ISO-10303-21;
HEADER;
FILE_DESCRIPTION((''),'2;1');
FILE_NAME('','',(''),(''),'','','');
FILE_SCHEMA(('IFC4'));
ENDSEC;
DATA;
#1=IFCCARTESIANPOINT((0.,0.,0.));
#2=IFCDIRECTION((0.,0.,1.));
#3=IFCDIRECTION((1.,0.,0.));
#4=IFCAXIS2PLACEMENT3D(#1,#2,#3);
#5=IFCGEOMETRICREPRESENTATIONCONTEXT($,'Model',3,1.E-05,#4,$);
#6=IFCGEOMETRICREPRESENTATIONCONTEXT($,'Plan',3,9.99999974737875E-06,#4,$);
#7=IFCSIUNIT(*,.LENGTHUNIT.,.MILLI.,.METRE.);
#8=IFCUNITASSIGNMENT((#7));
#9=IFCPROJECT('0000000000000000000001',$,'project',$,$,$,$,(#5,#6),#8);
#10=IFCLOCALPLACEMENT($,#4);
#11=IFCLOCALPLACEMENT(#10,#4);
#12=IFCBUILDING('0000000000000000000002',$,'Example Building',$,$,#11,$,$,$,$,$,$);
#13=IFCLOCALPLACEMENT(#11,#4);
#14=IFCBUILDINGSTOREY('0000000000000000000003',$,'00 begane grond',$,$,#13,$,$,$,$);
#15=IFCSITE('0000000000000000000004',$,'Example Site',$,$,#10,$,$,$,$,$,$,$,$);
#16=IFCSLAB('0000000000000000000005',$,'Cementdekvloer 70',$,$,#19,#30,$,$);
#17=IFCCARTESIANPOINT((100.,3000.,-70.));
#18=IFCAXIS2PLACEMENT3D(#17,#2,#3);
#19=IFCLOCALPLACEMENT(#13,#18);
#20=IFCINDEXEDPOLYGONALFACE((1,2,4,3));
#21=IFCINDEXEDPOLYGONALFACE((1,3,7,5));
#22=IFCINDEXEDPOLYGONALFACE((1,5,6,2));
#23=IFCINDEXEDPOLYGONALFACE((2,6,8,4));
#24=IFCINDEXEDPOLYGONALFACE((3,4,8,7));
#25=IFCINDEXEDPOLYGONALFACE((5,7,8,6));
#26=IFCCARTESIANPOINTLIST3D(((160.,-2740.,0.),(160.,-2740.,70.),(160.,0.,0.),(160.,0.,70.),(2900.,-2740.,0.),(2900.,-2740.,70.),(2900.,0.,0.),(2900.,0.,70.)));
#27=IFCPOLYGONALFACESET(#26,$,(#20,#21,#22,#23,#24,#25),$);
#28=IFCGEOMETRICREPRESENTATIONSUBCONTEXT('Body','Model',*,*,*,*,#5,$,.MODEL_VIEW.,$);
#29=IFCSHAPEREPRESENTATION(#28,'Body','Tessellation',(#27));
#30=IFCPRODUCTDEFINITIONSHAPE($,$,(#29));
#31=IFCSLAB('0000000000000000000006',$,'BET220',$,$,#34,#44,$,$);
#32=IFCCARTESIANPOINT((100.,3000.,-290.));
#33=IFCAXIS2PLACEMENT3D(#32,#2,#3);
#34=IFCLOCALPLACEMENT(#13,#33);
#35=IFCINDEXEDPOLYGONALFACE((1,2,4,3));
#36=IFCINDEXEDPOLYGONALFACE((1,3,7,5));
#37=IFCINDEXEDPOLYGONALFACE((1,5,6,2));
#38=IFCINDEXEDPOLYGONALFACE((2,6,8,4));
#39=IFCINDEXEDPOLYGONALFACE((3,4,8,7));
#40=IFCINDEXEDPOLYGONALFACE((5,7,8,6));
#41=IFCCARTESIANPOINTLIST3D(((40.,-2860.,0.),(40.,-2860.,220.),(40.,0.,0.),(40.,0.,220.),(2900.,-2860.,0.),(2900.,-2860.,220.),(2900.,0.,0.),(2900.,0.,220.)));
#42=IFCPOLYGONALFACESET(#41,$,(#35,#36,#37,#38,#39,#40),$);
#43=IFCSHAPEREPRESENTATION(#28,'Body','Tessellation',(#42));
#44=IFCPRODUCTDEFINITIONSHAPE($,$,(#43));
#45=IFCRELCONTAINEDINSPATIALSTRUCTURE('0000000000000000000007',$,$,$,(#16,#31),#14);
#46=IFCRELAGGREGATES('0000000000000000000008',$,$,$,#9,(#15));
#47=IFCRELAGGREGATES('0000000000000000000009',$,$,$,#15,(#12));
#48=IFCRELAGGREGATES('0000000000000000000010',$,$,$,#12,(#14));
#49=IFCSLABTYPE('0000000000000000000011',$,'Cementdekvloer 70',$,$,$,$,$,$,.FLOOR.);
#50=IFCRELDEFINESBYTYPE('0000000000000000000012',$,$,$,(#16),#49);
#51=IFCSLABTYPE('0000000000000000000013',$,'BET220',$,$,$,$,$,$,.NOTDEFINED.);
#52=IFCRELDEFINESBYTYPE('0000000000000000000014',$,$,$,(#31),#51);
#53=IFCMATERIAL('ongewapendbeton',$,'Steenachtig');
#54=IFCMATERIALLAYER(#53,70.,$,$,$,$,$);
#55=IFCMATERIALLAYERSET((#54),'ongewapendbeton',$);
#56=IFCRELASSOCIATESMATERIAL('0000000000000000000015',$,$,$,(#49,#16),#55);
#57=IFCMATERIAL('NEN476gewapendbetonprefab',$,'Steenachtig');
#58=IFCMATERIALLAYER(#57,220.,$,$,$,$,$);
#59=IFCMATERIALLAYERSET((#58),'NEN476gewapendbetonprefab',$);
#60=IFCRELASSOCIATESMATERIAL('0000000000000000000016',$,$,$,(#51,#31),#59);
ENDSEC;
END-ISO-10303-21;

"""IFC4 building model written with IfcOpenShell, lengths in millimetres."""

from ifc_helpers import new_model, si_unit, frame, origin_with_axes, place, context, subcontext, project, spatial, line, indexed_curve, outline, extrude, material, layer, layer_set, layer_usage, type_object, element, save


model = new_model("IFC4")

# Units and contexts
model_context = context("Model", 3, precision=1e-05, world=origin_with_axes())
plan_context = context("Plan", 3, precision=9.99999974737875e-06, world=origin_with_axes())
body_context = subcontext(model_context, "Body", "Model", "MODEL_VIEW")
ifc_project = project(units=[si_unit("LENGTHUNIT", "METRE", prefix="MILLI")], contexts=[model_context, plan_context])

# Site, building, storey
site_placement = place(None, frame((0.0, 0.0, 0.0), z_axis=(0.0, 0.0, 1.0), x_axis=(1.0, 0.0, 0.0)))
site = spatial("IfcSite", under=ifc_project, at=site_placement, Name="Example Site")
building_placement = place(site_placement, origin_with_axes())
building = spatial("IfcBuilding", under=site, at=building_placement, Name="Example Building")
storey_placement = place(building_placement, origin_with_axes())
storey = spatial("IfcBuildingStorey", under=building, at=storey_placement, Name="00 begane grond")

# Slabs
ifc_material_1 = material(Name="ongewapendbeton", Category="Steenachtig")
ifc_layer_1 = layer(ifc_material_1, 70.0)
ifc_layer_set_1 = layer_set([ifc_layer_1], Name="ongewapendbeton")
slab_type_1 = type_object("IfcSlabType", Name="Cementdekvloer 70", PredefinedType="FLOOR", material=ifc_layer_set_1)
ifc_layer_usage_1 = layer_usage(ifc_layer_set_1, "AXIS3", "POSITIVE", 0.0)
slab_1_placement = place(storey_placement, frame((100.0, 3000.0, -70.0), z_axis=(0.0, 0.0, 1.0), x_axis=(1.0, 0.0, 0.0)))
element("IfcSlab", 1, at=slab_1_placement, inside=storey, type_object=slab_type_1, material=ifc_layer_usage_1, Name="Cementdekvloer 70", context=body_context, shape_type="SweptSolid", body=[
    extrude(outline(indexed_curve([(2900.0, 0.0), (2900.0, -2740.0), (160.0, -2740.0), (160.0, 0.0)], segments=[line(4, 1), line(1, 2), line(2, 3), line(3, 4)], self_intersect=False)), None, (0.0, 0.0, 1.0), 70.0),
])
ifc_material_2 = material(Name="NEN476gewapendbetonprefab", Category="Steenachtig")
ifc_layer_2 = layer(ifc_material_2, 220.0)
ifc_layer_set_2 = layer_set([ifc_layer_2], Name="NEN476gewapendbetonprefab")
slab_type_2 = type_object("IfcSlabType", Name="BET220", PredefinedType="NOTDEFINED", material=ifc_layer_set_2)
ifc_layer_usage_2 = layer_usage(ifc_layer_set_2, "AXIS3", "POSITIVE", 0.0)
slab_2_placement = place(storey_placement, frame((100.0, 3000.0, -290.0), z_axis=(0.0, 0.0, 1.0), x_axis=(1.0, 0.0, 0.0)))
element("IfcSlab", 2, at=slab_2_placement, inside=storey, type_object=slab_type_2, material=ifc_layer_usage_2, Name="BET220", context=body_context, shape_type="SweptSolid", body=[
    extrude(outline(indexed_curve([(2900.0, 0.0), (2900.0, -2860.0), (40.0, -2860.0), (40.0, 0.0)], segments=[line(4, 1), line(1, 2), line(2, 3), line(3, 4)], self_intersect=False)), None, (0.0, 0.0, 1.0), 220.0),
])

save(model, "model.ifc")
